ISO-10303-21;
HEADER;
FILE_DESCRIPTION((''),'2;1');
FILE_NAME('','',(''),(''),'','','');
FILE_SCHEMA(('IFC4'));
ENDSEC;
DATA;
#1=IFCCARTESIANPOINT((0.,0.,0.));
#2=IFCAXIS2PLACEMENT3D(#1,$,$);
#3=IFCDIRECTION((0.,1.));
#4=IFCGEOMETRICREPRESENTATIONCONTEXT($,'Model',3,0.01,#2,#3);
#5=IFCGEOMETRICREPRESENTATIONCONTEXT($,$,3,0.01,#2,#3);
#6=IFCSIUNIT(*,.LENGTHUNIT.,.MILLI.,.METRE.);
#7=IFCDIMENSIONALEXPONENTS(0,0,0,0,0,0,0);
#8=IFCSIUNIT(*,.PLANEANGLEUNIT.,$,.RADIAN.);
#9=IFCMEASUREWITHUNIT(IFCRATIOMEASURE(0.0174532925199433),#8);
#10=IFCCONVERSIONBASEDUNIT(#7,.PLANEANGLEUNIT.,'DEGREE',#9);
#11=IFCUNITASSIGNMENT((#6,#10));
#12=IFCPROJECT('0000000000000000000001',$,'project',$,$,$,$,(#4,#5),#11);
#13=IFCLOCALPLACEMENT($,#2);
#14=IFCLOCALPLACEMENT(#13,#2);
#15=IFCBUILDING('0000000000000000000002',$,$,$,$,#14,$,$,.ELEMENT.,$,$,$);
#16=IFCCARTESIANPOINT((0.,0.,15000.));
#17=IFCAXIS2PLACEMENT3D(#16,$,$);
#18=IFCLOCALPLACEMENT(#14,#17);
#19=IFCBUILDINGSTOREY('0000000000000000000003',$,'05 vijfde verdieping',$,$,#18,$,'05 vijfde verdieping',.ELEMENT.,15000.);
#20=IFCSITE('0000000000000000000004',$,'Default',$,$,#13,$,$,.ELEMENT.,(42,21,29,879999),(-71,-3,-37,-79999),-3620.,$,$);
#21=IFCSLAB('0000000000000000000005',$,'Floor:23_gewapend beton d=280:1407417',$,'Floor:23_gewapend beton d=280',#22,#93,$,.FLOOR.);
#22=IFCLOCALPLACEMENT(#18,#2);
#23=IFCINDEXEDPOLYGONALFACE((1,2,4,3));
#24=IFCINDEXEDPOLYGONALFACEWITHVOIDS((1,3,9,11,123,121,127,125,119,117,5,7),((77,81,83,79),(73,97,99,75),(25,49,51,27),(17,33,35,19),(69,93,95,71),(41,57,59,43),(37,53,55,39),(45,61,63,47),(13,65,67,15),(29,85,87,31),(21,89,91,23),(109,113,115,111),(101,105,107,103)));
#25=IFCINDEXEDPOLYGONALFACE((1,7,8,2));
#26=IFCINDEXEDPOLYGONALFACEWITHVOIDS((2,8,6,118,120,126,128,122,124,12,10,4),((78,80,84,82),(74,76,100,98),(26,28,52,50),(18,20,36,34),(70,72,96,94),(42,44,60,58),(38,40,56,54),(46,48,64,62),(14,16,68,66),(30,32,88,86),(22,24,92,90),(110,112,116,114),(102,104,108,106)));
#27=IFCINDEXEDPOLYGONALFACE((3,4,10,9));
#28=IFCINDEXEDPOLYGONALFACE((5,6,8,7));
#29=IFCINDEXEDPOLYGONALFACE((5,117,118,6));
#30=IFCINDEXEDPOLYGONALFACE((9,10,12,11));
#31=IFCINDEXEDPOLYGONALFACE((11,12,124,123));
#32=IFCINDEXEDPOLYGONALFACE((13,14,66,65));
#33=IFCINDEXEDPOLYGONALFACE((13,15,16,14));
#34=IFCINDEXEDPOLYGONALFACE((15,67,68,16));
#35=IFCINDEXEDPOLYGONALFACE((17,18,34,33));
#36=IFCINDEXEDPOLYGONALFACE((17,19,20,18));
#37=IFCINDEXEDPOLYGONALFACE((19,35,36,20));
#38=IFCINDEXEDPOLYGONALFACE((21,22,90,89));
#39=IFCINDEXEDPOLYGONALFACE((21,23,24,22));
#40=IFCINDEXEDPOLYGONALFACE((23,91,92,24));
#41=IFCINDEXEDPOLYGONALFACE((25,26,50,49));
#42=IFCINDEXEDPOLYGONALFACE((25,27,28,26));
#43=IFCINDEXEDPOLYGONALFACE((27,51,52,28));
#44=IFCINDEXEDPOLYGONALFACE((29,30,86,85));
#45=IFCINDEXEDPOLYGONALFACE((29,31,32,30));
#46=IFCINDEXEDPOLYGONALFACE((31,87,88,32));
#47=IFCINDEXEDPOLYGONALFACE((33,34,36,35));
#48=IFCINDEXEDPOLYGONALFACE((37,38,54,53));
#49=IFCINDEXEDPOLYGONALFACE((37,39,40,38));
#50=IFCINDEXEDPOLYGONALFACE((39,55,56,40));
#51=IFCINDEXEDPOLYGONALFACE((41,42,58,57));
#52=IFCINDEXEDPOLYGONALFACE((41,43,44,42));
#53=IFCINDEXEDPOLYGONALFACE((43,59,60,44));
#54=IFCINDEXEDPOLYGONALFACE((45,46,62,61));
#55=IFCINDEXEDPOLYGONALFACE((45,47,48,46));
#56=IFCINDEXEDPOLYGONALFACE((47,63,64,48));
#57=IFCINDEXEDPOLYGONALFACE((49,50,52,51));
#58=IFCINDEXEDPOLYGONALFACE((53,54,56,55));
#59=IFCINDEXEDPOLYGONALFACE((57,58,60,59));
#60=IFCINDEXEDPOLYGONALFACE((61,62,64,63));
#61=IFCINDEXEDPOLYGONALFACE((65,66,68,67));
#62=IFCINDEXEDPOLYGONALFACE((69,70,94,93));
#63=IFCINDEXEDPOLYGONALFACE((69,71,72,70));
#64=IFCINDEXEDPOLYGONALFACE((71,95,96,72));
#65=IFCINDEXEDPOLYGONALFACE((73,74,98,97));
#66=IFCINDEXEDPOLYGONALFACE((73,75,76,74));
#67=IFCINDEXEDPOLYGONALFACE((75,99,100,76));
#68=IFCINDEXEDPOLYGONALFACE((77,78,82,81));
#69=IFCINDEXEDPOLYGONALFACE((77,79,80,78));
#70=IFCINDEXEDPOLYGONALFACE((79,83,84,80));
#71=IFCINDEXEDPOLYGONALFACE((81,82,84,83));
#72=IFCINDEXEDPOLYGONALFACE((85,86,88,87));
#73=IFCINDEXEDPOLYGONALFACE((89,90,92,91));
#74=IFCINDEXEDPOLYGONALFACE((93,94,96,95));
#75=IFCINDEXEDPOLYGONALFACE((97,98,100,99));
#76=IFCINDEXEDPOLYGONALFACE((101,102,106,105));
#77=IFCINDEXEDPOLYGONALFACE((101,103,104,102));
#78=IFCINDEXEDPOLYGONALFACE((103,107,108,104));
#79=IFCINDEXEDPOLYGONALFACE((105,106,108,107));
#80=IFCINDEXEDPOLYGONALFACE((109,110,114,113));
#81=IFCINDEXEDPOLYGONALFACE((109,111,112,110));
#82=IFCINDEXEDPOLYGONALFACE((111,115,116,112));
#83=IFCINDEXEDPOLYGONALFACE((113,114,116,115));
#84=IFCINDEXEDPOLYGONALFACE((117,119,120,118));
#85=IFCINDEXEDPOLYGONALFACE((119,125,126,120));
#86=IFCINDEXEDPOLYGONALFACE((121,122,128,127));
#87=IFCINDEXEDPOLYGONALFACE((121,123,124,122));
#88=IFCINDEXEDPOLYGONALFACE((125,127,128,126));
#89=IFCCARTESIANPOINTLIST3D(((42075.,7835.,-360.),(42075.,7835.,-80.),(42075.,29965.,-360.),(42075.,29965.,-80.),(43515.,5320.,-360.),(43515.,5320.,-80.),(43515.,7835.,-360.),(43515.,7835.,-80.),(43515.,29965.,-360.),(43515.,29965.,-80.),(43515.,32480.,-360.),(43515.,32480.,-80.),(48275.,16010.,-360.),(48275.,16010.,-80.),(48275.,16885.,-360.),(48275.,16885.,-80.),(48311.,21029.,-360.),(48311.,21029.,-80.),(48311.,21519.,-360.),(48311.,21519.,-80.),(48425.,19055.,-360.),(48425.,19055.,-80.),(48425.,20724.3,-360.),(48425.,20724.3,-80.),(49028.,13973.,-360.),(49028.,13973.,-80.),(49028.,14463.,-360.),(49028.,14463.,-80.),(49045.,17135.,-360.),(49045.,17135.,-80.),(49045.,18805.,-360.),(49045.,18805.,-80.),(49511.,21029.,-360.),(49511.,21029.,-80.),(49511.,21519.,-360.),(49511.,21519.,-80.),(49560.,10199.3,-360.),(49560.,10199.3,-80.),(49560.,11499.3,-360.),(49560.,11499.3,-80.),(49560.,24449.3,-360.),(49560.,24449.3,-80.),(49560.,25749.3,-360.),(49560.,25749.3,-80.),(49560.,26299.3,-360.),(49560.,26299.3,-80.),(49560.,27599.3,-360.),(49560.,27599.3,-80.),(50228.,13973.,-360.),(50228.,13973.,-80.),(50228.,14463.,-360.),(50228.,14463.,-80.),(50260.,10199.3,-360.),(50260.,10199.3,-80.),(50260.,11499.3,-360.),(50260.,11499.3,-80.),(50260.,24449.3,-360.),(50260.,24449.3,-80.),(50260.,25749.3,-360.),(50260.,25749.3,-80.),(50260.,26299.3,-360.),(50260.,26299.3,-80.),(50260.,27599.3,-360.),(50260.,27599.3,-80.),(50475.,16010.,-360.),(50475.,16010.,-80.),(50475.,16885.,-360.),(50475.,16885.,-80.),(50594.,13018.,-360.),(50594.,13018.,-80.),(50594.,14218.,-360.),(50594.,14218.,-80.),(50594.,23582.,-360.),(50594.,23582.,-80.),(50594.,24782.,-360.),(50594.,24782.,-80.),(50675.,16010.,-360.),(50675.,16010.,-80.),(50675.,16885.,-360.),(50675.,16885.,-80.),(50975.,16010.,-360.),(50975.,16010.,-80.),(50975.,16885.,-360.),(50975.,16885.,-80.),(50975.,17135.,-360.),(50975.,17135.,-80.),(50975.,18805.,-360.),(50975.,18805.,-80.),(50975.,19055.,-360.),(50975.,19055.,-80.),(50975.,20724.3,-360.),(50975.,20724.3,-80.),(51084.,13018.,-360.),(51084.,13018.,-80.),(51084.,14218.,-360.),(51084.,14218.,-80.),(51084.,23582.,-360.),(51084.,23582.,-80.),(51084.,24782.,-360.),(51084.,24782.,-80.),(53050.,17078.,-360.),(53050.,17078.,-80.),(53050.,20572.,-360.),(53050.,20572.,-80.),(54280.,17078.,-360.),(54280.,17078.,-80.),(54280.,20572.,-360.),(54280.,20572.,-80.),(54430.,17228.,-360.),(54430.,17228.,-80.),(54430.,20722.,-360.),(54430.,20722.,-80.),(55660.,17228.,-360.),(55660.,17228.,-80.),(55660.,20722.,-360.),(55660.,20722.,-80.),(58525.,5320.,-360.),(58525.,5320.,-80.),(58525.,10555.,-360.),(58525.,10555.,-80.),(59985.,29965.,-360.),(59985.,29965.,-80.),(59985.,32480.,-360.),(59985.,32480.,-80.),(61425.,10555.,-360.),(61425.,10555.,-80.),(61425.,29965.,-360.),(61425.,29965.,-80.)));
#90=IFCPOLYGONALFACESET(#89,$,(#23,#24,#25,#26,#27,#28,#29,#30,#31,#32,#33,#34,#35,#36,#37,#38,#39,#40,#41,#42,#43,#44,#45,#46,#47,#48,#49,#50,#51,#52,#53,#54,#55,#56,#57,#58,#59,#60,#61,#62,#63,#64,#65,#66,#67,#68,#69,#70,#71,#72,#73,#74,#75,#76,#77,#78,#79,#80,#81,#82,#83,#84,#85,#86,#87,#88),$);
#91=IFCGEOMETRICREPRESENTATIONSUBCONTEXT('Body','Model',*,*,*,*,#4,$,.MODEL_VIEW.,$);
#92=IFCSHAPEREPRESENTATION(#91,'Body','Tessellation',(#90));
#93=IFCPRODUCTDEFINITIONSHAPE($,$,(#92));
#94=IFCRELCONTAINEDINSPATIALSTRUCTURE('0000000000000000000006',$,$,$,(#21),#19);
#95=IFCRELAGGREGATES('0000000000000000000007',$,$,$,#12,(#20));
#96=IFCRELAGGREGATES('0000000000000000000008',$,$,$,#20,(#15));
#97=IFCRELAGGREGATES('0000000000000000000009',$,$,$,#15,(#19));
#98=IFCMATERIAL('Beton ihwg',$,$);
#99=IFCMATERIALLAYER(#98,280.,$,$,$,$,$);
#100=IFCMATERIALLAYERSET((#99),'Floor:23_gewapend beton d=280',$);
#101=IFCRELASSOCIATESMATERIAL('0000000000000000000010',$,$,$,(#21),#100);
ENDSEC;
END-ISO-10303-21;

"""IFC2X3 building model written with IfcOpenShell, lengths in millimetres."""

from ifc_helpers import new_model, entity, si_unit, converted_unit, direction, frame, frame_2d, origin, place, context, subcontext, project, spatial, polyline, rectangle, outline, extrude, material, layer, layer_set, layer_usage, element, save


model = new_model("IFC2X3")

# Units and contexts
model_context = context("Model", 3, precision=0.01, world=origin(), true_north=direction((0.0, 1.0)))
context_of_model = context(None, 3, precision=0.01, world=origin(), true_north=direction((0.0, 1.0)))
body_context = subcontext(model_context, "Body", "Model", "MODEL_VIEW")
ifc_project = project(units=[si_unit("LENGTHUNIT", "METRE", prefix="MILLI"), converted_unit("PLANEANGLEUNIT", "DEGREE", entity("IfcRatioMeasure", 0.0174532925199433), si_unit("PLANEANGLEUNIT", "RADIAN"), dimensions=[0, 0, 0, 0, 0, 0, 0])], contexts=[model_context, context_of_model])

# Site, building, storey
site_placement = place(None, origin())
site = spatial("IfcSite", under=ifc_project, at=site_placement, Name="Default", CompositionType="ELEMENT", RefLatitude=(42, 21, 29, 879999), RefLongitude=(-71, -3, -37, -79999), RefElevation=-3620.0)
building_placement = place(site_placement, origin())
building = spatial("IfcBuilding", under=site, at=building_placement, CompositionType="ELEMENT")
storey_placement = place(building_placement, frame((0.0, 0.0, 15000.0)))
storey = spatial("IfcBuildingStorey", under=building, at=storey_placement, Name="05 vijfde verdieping", LongName="05 vijfde verdieping", CompositionType="ELEMENT", Elevation=15000.0)

# Slab, openings
ifc_material_1 = material(Name="Beton ihwg")
ifc_layer_1 = layer(ifc_material_1, 280.0)
ifc_layer_set_1 = layer_set([ifc_layer_1], Name="Floor:23_gewapend beton d=280")
ifc_layer_usage_1 = layer_usage(ifc_layer_set_1, "AXIS3", "POSITIVE", 0.0)
slab_1_placement = place(storey_placement, frame((42075.0, 5320.0, -360.0)))
slab_1 = element("IfcSlab", 1, at=slab_1_placement, inside=storey, material=ifc_layer_usage_1, Name="Floor:23_gewapend beton d=280:1407417", ObjectType="Floor:23_gewapend beton d=280", PredefinedType="FLOOR", context=body_context, shape_type="SweptSolid", body=[
    extrude(outline(polyline([(8235.0, 13580.0), (-8235.0, 13580.0), (-8235.0, 11065.0), (-9675.0, 11065.0), (-9675.0, -8345.0), (-6775.0, -8345.0), (-6775.0, -13580.0), (8235.0, -13580.0), (8235.0, -11065.0), (9675.0, -11065.0), (9675.0, 11065.0), (8235.0, 11065.0), (8235.0, 13580.0)])), frame((9675.0, 13580.0, 280.0), z_axis=(0.0, 0.0, -1.0), x_axis=(-1.0, 0.0, 0.0)), (0.0, 0.0, 1.0), 280.0),
])
opening_1_placement = place(storey_placement, frame((42075.0, 5320.0, -360.0)))
element("IfcOpeningElement", 2, at=opening_1_placement, cuts=slab_1, ObjectType="Opening", context=body_context, shape_type="SweptSolid", body=[
    extrude(rectangle(XDim=1669.3, YDim=2550.0, at=frame_2d((2050.0, 989.6), x_axis=(0.0, 1.0))), frame((9675.0, 13580.0, 280.0), z_axis=(0.0, 0.0, -1.0), x_axis=(-1.0, 0.0, 0.0)), (0.0, 0.0, 1.0), 280.0),
])
opening_2_placement = place(storey_placement, frame((42075.0, 5320.0, -360.0)))
element("IfcOpeningElement", 3, at=opening_2_placement, cuts=slab_1, ObjectType="Opening", context=body_context, shape_type="SweptSolid", body=[
    extrude(rectangle(XDim=1670.0, YDim=1930.0, at=frame_2d((1740.0, -930.0), x_axis=(0.0, 1.0))), frame((9675.0, 13580.0, 280.0), z_axis=(0.0, 0.0, -1.0), x_axis=(-1.0, 0.0, 0.0)), (0.0, 0.0, 1.0), 280.0),
])
opening_3_placement = place(storey_placement, frame((42075.0, 5320.0, -360.0)))
element("IfcOpeningElement", 4, at=opening_3_placement, cuts=slab_1, ObjectType="Opening", context=body_context, shape_type="SweptSolid", body=[
    extrude(rectangle(XDim=1300.0, YDim=700.0, at=frame_2d((1840.0, 8049.3), x_axis=(0.0, 1.0))), frame((9675.0, 13580.0, 280.0), z_axis=(0.0, 0.0, -1.0), x_axis=(-1.0, 0.0, 0.0)), (0.0, 0.0, 1.0), 280.0),
])
opening_4_placement = place(storey_placement, frame((42075.0, 5320.0, -360.0)))
element("IfcOpeningElement", 5, at=opening_4_placement, cuts=slab_1, ObjectType="Opening", context=body_context, shape_type="SweptSolid", body=[
    extrude(rectangle(XDim=1300.0, YDim=700.0, at=frame_2d((1840.0, 6199.3), x_axis=(0.0, 1.0))), frame((9675.0, 13580.0, 280.0), z_axis=(0.0, 0.0, -1.0), x_axis=(-1.0, 0.0, 0.0)), (0.0, 0.0, 1.0), 280.0),
])
opening_5_placement = place(storey_placement, frame((42075.0, 5320.0, -360.0)))
element("IfcOpeningElement", 6, at=opening_5_placement, cuts=slab_1, ObjectType="Opening", context=body_context, shape_type="SweptSolid", body=[
    extrude(rectangle(XDim=1300.0, YDim=700.0, at=frame_2d((1840.0, -8050.7), x_axis=(0.0, 1.0))), frame((9675.0, 13580.0, 280.0), z_axis=(0.0, 0.0, -1.0), x_axis=(-1.0, 0.0, 0.0)), (0.0, 0.0, 1.0), 280.0),
])
opening_6_placement = place(storey_placement, frame((42075.0, 5320.0, -360.0)))
element("IfcOpeningElement", 7, at=opening_6_placement, cuts=slab_1, ObjectType="Opening", context=body_context, shape_type="SweptSolid", body=[
    extrude(rectangle(XDim=875.0, YDim=2200.0, at=frame_2d((2375.0, -2452.5), x_axis=(0.0, 1.0))), frame((9675.0, 13580.0, 280.0), z_axis=(0.0, 0.0, -1.0), x_axis=(-1.0, 0.0, 0.0)), (0.0, 0.0, 1.0), 280.0),
])
opening_7_placement = place(storey_placement, frame((42075.0, 5320.0, -360.0)))
element("IfcOpeningElement", 8, at=opening_7_placement, cuts=slab_1, ObjectType="Opening", context=body_context, shape_type="SweptSolid", body=[
    extrude(rectangle(XDim=875.0, YDim=300.0, at=frame_2d((925.0, -2452.5), x_axis=(0.0, 1.0))), frame((9675.0, 13580.0, 280.0), z_axis=(0.0, 0.0, -1.0), x_axis=(-1.0, 0.0, 0.0)), (0.0, 0.0, 1.0), 280.0),
])
opening_8_placement = place(storey_placement, frame((42075.0, 5320.0, -360.0)))
element("IfcOpeningElement", 9, at=opening_8_placement, cuts=slab_1, ObjectType="Opening", context=body_context, shape_type="SweptSolid", body=[
    extrude(rectangle(XDim=3494.0, YDim=1230.0, at=frame_2d((-3295.0, 75.0), x_axis=(0.0, 1.0))), frame((9675.0, 13580.0, 280.0), z_axis=(0.0, 0.0, -1.0), x_axis=(-1.0, 0.0, 0.0)), (0.0, 0.0, 1.0), 280.0),
])
opening_9_placement = place(storey_placement, frame((42075.0, 5320.0, -360.0)))
element("IfcOpeningElement", 10, at=opening_9_placement, cuts=slab_1, ObjectType="Opening", context=body_context, shape_type="SweptSolid", body=[
    extrude(rectangle(XDim=3494.0, YDim=1230.0, at=frame_2d((-1915.0, -75.0), x_axis=(0.0, 1.0))), frame((9675.0, 13580.0, 280.0), z_axis=(0.0, 0.0, -1.0), x_axis=(-1.0, 0.0, 0.0)), (0.0, 0.0, 1.0), 280.0),
])
opening_10_placement = place(storey_placement, frame((42075.0, 5320.0, -360.0)))
element("IfcOpeningElement", 11, at=opening_10_placement, cuts=slab_1, ObjectType="Opening", context=body_context, shape_type="SweptSolid", body=[
    extrude(rectangle(XDim=490.0, YDim=1200.0, at=frame_2d((911.0, 5282.0), x_axis=(-1.0, 0.0))), frame((9675.0, 13580.0, 280.0), z_axis=(0.0, 0.0, -1.0), x_axis=(-1.0, 0.0, 0.0)), (0.0, 0.0, 1.0), 280.0),
])
opening_11_placement = place(storey_placement, frame((42075.0, 5320.0, -360.0)))
element("IfcOpeningElement", 12, at=opening_11_placement, cuts=slab_1, ObjectType="Opening", context=body_context, shape_type="SweptSolid", body=[
    extrude(rectangle(XDim=490.0, YDim=1200.0, at=frame_2d((2839.0, 2374.0), x_axis=(0.0, 1.0))), frame((9675.0, 13580.0, 280.0), z_axis=(0.0, 0.0, -1.0), x_axis=(-1.0, 0.0, 0.0)), (0.0, 0.0, 1.0), 280.0),
])
opening_12_placement = place(storey_placement, frame((42075.0, 5320.0, -360.0)))
element("IfcOpeningElement", 13, at=opening_12_placement, cuts=slab_1, ObjectType="Opening", context=body_context, shape_type="SweptSolid", body=[
    extrude(rectangle(XDim=490.0, YDim=1200.0, at=frame_2d((911.0, -5282.0), x_axis=(-1.0, 0.0))), frame((9675.0, 13580.0, 280.0), z_axis=(0.0, 0.0, -1.0), x_axis=(-1.0, 0.0, 0.0)), (0.0, 0.0, 1.0), 280.0),
])
opening_13_placement = place(storey_placement, frame((42075.0, 5320.0, -360.0)))
element("IfcOpeningElement", 14, at=opening_13_placement, cuts=slab_1, ObjectType="Opening", context=body_context, shape_type="SweptSolid", body=[
    extrude(rectangle(XDim=490.0, YDim=1200.0, at=frame_2d((2122.0, -4682.0), x_axis=(0.0, 1.0))), frame((9675.0, 13580.0, 280.0), z_axis=(0.0, 0.0, -1.0), x_axis=(-1.0, 0.0, 0.0)), (0.0, 0.0, 1.0), 280.0),
])

save(model, "model.ifc")
